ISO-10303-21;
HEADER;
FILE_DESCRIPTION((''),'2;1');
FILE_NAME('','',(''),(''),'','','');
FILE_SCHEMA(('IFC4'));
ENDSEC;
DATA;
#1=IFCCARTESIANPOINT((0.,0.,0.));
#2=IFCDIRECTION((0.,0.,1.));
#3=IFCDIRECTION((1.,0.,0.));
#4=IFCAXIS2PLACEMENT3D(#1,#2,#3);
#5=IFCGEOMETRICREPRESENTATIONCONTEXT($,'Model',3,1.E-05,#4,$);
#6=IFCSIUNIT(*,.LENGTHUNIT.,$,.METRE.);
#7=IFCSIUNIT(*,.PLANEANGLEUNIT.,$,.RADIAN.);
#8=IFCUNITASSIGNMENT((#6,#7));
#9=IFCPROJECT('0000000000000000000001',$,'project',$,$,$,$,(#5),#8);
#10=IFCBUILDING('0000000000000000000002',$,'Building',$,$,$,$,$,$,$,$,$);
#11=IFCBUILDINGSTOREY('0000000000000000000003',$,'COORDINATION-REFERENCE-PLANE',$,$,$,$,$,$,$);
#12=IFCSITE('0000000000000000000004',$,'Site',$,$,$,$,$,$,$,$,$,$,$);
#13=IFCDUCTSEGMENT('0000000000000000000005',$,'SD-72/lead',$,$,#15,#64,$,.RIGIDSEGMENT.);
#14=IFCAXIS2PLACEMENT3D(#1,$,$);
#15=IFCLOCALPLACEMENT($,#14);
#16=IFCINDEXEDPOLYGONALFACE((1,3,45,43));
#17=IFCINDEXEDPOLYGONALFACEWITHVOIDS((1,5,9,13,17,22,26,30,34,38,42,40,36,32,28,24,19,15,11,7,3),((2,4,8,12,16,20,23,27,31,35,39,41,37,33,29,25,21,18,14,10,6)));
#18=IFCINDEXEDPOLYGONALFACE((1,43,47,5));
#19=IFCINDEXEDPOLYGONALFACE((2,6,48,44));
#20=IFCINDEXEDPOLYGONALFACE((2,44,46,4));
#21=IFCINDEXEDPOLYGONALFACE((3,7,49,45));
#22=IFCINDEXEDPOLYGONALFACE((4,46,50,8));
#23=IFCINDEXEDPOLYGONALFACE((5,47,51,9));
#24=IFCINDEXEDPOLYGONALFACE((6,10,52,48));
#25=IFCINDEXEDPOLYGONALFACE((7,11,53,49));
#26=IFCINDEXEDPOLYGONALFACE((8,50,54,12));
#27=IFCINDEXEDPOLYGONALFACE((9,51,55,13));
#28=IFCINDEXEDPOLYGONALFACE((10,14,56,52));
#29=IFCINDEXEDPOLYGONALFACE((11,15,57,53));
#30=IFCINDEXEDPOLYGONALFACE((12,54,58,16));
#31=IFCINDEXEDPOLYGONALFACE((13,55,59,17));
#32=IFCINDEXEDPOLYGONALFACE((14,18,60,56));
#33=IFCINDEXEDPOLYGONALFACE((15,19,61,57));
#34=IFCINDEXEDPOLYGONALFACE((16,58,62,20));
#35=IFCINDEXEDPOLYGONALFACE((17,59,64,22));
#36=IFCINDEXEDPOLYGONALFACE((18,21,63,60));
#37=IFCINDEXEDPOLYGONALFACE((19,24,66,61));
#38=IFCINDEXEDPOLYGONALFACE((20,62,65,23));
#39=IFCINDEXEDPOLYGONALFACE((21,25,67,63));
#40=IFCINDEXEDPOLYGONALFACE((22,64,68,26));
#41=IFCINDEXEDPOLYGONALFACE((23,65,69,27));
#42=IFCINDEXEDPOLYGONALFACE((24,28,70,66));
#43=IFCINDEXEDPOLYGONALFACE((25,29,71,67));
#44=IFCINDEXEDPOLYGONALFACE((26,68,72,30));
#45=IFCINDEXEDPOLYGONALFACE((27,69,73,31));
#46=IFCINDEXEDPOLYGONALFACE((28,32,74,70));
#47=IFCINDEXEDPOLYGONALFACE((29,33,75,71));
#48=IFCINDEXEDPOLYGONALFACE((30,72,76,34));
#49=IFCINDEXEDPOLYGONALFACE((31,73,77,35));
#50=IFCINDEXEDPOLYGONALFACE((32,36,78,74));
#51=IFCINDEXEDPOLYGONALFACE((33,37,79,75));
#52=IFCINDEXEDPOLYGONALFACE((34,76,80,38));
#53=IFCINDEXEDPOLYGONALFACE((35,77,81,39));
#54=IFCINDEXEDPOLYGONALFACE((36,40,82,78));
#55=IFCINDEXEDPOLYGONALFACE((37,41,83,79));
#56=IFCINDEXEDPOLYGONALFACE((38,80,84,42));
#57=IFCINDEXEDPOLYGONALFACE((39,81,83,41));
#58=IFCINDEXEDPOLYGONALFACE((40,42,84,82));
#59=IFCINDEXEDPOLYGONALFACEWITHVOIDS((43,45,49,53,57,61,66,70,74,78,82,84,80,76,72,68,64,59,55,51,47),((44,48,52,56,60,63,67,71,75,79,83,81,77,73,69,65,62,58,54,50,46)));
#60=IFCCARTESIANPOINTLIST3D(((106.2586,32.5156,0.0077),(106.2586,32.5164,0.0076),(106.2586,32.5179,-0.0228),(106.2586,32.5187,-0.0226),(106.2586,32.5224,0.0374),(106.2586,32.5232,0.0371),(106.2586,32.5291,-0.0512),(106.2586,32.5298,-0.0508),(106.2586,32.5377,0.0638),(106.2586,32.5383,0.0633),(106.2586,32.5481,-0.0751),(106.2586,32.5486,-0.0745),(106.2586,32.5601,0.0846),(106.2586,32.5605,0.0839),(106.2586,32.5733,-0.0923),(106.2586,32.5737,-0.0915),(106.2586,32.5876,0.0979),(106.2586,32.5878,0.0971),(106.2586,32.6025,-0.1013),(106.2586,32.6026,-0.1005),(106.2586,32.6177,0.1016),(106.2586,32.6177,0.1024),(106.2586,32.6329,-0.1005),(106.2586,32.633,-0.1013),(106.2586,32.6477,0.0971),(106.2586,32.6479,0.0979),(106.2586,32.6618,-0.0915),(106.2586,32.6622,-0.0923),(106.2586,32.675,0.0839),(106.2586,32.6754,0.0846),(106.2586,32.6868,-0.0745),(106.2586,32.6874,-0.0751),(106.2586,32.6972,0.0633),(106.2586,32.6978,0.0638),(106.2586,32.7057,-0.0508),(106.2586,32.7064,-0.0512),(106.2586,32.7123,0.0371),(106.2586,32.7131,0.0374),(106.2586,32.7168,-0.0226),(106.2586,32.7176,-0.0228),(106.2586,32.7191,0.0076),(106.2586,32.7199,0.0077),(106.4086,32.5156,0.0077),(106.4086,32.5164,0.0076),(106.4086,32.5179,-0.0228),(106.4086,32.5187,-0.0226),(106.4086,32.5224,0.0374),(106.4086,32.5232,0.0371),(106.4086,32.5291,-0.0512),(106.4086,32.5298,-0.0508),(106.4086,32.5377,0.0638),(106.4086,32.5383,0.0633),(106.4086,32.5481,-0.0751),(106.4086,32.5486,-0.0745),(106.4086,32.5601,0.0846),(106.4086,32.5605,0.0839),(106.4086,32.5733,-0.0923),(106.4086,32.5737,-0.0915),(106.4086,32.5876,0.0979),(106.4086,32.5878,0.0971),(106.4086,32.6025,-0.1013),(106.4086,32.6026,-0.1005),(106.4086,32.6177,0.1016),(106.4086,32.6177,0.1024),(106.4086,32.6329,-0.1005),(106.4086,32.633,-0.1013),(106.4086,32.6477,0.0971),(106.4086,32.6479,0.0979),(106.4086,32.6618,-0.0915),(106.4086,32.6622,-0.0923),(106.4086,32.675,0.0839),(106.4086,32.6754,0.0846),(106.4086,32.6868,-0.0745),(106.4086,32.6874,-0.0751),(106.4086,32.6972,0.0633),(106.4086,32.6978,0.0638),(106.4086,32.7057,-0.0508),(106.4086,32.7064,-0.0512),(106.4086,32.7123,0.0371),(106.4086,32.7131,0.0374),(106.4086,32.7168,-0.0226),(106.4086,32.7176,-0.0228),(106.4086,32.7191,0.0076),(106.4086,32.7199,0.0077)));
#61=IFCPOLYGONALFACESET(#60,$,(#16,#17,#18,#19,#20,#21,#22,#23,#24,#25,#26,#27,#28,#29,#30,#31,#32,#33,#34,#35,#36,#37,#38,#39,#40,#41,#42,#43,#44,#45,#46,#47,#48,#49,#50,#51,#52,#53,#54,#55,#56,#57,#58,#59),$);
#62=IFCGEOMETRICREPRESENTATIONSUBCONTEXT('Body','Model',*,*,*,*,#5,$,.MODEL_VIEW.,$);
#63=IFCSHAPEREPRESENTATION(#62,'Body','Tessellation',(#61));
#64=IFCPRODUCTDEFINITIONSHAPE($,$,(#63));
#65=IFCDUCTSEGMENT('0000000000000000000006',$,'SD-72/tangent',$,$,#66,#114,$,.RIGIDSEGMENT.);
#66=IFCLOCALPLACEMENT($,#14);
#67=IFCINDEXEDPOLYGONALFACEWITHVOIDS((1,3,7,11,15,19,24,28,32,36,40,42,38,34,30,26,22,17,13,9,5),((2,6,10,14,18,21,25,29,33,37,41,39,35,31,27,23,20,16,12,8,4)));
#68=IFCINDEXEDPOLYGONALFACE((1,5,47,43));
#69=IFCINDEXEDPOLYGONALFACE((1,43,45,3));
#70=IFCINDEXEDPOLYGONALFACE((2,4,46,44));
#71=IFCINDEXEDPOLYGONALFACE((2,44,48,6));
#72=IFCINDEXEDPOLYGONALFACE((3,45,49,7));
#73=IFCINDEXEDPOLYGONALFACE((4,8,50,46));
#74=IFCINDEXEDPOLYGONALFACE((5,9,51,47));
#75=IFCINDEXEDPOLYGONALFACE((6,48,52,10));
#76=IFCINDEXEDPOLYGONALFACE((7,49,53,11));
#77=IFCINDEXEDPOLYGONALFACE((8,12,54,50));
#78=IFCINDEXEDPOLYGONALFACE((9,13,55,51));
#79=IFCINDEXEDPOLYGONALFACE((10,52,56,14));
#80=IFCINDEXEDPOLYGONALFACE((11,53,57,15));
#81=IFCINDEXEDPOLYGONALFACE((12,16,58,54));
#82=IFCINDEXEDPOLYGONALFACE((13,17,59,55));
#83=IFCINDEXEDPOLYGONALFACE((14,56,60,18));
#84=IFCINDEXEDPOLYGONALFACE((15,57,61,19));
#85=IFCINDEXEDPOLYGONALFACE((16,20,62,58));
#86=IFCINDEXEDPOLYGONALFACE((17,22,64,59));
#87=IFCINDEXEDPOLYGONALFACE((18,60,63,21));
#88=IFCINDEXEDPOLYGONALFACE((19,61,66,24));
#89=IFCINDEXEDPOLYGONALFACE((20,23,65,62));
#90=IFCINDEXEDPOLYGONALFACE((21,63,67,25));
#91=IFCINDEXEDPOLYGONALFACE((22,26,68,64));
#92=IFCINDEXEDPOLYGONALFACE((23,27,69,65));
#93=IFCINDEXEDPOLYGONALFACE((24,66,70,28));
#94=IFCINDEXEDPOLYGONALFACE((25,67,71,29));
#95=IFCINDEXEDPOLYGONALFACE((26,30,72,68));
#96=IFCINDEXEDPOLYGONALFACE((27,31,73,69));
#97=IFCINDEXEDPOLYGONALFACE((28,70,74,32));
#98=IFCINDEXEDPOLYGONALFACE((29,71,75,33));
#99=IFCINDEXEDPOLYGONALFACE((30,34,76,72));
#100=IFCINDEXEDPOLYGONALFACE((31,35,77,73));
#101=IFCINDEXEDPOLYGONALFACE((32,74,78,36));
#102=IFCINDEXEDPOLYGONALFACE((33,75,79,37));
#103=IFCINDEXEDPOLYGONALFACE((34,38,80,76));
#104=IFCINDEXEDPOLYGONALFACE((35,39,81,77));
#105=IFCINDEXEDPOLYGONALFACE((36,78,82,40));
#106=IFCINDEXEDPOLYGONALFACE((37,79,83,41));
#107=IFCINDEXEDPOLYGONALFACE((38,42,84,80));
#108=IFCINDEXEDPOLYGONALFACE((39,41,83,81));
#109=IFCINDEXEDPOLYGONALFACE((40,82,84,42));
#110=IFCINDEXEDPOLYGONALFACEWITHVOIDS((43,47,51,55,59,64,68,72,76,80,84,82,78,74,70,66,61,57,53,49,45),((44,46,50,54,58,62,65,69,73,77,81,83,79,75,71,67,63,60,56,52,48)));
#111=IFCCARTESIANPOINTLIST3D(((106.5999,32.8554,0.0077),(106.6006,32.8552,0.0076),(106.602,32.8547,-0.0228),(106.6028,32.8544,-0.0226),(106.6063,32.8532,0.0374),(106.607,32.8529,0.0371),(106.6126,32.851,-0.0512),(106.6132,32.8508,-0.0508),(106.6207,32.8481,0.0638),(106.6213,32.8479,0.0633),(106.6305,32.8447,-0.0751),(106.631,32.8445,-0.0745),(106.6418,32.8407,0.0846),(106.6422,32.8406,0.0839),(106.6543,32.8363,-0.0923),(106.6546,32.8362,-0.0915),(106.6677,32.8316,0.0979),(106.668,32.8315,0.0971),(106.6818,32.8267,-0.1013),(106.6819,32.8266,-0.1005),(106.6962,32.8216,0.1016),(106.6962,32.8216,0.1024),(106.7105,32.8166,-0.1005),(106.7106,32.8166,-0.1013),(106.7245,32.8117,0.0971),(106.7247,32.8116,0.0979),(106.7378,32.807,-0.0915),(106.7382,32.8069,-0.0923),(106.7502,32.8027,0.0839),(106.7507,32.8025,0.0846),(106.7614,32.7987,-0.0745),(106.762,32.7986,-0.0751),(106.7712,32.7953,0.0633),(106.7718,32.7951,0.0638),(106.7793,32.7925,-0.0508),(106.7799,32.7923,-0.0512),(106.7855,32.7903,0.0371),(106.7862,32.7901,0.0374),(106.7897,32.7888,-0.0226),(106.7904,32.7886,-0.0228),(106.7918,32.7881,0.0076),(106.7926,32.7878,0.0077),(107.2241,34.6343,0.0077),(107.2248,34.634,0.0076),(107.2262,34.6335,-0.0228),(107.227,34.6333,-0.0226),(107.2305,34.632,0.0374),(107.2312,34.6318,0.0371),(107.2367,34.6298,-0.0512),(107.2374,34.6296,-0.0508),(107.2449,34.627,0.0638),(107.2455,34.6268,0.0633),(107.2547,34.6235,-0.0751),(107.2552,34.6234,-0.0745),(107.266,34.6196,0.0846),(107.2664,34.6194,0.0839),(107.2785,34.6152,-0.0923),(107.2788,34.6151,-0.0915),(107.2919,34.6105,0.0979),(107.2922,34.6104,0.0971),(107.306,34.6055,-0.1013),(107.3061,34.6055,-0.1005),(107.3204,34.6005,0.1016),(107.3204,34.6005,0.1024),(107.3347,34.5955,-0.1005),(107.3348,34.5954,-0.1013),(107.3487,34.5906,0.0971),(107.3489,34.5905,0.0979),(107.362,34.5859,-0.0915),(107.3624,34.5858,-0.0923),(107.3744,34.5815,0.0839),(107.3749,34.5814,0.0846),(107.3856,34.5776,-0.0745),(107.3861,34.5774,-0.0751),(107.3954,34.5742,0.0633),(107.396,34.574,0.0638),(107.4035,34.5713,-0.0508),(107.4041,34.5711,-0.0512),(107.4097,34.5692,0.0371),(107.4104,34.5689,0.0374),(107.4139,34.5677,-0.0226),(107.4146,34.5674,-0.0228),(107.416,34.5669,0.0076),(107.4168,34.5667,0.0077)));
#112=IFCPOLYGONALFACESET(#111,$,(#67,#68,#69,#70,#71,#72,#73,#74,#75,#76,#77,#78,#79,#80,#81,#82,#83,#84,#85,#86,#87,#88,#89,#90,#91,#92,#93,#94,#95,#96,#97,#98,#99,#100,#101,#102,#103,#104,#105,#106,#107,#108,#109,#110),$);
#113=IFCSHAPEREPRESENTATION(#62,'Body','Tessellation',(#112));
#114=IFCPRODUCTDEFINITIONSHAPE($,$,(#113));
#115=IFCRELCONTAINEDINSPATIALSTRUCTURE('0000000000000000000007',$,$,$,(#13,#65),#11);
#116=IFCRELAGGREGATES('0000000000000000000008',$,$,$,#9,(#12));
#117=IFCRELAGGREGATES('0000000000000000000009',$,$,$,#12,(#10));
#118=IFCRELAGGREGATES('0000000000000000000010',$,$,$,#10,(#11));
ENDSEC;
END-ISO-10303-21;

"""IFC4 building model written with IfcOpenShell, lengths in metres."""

from ifc_helpers import new_model, si_unit, frame, origin_with_axes, place, context, subcontext, project, spatial, hollow_circle, extrude, element, save


model = new_model("IFC4")

# Units and contexts
model_context = context("Model", 3, precision=1e-05, world=origin_with_axes())
body_context_1 = subcontext(model_context, "Body", "Model", "MODEL_VIEW")
ifc_project = project(units=[si_unit("LENGTHUNIT", "METRE"), si_unit("PLANEANGLEUNIT", "RADIAN")], contexts=[model_context])

# Site, building, storey
site = spatial("IfcSite", under=ifc_project, Name="Site")
building = spatial("IfcBuilding", under=site, Name="Building")
storey = spatial("IfcBuildingStorey", under=building, Name="COORDINATION-REFERENCE-PLANE")

# Duct segment
duct_segment_1_placement = place(None, frame((106.2586, 32.6177, 0.0), z_axis=(1.0, 0.0, 0.0), x_axis=(0.0, 0.0, 1.0)))
element("IfcDuctSegment", 1, at=duct_segment_1_placement, inside=storey, Name="SD-72/lead", PredefinedType="RIGIDSEGMENT", context=body_context_1, shape_type="SweptSolid", body=[
    extrude(hollow_circle(Radius=0.1024, WallThickness=0.0008), origin_with_axes(), (0.0, 0.0, 1.0), 0.15),
])

# Duct segment
duct_segment_2_placement = place(None, frame((106.6962, 32.8216, 0.0), z_axis=(0.331106, 0.943594, 0.0), x_axis=(0.0, 0.0, 1.0)))
element("IfcDuctSegment", 2, at=duct_segment_2_placement, inside=storey, Name="SD-72/tangent", PredefinedType="RIGIDSEGMENT", context=body_context_1, shape_type="SweptSolid", body=[
    extrude(hollow_circle(Radius=0.1024, WallThickness=0.0008), origin_with_axes(), (0.0, 0.0, 1.0), 1.8852),
])

save(model, "model.ifc")
